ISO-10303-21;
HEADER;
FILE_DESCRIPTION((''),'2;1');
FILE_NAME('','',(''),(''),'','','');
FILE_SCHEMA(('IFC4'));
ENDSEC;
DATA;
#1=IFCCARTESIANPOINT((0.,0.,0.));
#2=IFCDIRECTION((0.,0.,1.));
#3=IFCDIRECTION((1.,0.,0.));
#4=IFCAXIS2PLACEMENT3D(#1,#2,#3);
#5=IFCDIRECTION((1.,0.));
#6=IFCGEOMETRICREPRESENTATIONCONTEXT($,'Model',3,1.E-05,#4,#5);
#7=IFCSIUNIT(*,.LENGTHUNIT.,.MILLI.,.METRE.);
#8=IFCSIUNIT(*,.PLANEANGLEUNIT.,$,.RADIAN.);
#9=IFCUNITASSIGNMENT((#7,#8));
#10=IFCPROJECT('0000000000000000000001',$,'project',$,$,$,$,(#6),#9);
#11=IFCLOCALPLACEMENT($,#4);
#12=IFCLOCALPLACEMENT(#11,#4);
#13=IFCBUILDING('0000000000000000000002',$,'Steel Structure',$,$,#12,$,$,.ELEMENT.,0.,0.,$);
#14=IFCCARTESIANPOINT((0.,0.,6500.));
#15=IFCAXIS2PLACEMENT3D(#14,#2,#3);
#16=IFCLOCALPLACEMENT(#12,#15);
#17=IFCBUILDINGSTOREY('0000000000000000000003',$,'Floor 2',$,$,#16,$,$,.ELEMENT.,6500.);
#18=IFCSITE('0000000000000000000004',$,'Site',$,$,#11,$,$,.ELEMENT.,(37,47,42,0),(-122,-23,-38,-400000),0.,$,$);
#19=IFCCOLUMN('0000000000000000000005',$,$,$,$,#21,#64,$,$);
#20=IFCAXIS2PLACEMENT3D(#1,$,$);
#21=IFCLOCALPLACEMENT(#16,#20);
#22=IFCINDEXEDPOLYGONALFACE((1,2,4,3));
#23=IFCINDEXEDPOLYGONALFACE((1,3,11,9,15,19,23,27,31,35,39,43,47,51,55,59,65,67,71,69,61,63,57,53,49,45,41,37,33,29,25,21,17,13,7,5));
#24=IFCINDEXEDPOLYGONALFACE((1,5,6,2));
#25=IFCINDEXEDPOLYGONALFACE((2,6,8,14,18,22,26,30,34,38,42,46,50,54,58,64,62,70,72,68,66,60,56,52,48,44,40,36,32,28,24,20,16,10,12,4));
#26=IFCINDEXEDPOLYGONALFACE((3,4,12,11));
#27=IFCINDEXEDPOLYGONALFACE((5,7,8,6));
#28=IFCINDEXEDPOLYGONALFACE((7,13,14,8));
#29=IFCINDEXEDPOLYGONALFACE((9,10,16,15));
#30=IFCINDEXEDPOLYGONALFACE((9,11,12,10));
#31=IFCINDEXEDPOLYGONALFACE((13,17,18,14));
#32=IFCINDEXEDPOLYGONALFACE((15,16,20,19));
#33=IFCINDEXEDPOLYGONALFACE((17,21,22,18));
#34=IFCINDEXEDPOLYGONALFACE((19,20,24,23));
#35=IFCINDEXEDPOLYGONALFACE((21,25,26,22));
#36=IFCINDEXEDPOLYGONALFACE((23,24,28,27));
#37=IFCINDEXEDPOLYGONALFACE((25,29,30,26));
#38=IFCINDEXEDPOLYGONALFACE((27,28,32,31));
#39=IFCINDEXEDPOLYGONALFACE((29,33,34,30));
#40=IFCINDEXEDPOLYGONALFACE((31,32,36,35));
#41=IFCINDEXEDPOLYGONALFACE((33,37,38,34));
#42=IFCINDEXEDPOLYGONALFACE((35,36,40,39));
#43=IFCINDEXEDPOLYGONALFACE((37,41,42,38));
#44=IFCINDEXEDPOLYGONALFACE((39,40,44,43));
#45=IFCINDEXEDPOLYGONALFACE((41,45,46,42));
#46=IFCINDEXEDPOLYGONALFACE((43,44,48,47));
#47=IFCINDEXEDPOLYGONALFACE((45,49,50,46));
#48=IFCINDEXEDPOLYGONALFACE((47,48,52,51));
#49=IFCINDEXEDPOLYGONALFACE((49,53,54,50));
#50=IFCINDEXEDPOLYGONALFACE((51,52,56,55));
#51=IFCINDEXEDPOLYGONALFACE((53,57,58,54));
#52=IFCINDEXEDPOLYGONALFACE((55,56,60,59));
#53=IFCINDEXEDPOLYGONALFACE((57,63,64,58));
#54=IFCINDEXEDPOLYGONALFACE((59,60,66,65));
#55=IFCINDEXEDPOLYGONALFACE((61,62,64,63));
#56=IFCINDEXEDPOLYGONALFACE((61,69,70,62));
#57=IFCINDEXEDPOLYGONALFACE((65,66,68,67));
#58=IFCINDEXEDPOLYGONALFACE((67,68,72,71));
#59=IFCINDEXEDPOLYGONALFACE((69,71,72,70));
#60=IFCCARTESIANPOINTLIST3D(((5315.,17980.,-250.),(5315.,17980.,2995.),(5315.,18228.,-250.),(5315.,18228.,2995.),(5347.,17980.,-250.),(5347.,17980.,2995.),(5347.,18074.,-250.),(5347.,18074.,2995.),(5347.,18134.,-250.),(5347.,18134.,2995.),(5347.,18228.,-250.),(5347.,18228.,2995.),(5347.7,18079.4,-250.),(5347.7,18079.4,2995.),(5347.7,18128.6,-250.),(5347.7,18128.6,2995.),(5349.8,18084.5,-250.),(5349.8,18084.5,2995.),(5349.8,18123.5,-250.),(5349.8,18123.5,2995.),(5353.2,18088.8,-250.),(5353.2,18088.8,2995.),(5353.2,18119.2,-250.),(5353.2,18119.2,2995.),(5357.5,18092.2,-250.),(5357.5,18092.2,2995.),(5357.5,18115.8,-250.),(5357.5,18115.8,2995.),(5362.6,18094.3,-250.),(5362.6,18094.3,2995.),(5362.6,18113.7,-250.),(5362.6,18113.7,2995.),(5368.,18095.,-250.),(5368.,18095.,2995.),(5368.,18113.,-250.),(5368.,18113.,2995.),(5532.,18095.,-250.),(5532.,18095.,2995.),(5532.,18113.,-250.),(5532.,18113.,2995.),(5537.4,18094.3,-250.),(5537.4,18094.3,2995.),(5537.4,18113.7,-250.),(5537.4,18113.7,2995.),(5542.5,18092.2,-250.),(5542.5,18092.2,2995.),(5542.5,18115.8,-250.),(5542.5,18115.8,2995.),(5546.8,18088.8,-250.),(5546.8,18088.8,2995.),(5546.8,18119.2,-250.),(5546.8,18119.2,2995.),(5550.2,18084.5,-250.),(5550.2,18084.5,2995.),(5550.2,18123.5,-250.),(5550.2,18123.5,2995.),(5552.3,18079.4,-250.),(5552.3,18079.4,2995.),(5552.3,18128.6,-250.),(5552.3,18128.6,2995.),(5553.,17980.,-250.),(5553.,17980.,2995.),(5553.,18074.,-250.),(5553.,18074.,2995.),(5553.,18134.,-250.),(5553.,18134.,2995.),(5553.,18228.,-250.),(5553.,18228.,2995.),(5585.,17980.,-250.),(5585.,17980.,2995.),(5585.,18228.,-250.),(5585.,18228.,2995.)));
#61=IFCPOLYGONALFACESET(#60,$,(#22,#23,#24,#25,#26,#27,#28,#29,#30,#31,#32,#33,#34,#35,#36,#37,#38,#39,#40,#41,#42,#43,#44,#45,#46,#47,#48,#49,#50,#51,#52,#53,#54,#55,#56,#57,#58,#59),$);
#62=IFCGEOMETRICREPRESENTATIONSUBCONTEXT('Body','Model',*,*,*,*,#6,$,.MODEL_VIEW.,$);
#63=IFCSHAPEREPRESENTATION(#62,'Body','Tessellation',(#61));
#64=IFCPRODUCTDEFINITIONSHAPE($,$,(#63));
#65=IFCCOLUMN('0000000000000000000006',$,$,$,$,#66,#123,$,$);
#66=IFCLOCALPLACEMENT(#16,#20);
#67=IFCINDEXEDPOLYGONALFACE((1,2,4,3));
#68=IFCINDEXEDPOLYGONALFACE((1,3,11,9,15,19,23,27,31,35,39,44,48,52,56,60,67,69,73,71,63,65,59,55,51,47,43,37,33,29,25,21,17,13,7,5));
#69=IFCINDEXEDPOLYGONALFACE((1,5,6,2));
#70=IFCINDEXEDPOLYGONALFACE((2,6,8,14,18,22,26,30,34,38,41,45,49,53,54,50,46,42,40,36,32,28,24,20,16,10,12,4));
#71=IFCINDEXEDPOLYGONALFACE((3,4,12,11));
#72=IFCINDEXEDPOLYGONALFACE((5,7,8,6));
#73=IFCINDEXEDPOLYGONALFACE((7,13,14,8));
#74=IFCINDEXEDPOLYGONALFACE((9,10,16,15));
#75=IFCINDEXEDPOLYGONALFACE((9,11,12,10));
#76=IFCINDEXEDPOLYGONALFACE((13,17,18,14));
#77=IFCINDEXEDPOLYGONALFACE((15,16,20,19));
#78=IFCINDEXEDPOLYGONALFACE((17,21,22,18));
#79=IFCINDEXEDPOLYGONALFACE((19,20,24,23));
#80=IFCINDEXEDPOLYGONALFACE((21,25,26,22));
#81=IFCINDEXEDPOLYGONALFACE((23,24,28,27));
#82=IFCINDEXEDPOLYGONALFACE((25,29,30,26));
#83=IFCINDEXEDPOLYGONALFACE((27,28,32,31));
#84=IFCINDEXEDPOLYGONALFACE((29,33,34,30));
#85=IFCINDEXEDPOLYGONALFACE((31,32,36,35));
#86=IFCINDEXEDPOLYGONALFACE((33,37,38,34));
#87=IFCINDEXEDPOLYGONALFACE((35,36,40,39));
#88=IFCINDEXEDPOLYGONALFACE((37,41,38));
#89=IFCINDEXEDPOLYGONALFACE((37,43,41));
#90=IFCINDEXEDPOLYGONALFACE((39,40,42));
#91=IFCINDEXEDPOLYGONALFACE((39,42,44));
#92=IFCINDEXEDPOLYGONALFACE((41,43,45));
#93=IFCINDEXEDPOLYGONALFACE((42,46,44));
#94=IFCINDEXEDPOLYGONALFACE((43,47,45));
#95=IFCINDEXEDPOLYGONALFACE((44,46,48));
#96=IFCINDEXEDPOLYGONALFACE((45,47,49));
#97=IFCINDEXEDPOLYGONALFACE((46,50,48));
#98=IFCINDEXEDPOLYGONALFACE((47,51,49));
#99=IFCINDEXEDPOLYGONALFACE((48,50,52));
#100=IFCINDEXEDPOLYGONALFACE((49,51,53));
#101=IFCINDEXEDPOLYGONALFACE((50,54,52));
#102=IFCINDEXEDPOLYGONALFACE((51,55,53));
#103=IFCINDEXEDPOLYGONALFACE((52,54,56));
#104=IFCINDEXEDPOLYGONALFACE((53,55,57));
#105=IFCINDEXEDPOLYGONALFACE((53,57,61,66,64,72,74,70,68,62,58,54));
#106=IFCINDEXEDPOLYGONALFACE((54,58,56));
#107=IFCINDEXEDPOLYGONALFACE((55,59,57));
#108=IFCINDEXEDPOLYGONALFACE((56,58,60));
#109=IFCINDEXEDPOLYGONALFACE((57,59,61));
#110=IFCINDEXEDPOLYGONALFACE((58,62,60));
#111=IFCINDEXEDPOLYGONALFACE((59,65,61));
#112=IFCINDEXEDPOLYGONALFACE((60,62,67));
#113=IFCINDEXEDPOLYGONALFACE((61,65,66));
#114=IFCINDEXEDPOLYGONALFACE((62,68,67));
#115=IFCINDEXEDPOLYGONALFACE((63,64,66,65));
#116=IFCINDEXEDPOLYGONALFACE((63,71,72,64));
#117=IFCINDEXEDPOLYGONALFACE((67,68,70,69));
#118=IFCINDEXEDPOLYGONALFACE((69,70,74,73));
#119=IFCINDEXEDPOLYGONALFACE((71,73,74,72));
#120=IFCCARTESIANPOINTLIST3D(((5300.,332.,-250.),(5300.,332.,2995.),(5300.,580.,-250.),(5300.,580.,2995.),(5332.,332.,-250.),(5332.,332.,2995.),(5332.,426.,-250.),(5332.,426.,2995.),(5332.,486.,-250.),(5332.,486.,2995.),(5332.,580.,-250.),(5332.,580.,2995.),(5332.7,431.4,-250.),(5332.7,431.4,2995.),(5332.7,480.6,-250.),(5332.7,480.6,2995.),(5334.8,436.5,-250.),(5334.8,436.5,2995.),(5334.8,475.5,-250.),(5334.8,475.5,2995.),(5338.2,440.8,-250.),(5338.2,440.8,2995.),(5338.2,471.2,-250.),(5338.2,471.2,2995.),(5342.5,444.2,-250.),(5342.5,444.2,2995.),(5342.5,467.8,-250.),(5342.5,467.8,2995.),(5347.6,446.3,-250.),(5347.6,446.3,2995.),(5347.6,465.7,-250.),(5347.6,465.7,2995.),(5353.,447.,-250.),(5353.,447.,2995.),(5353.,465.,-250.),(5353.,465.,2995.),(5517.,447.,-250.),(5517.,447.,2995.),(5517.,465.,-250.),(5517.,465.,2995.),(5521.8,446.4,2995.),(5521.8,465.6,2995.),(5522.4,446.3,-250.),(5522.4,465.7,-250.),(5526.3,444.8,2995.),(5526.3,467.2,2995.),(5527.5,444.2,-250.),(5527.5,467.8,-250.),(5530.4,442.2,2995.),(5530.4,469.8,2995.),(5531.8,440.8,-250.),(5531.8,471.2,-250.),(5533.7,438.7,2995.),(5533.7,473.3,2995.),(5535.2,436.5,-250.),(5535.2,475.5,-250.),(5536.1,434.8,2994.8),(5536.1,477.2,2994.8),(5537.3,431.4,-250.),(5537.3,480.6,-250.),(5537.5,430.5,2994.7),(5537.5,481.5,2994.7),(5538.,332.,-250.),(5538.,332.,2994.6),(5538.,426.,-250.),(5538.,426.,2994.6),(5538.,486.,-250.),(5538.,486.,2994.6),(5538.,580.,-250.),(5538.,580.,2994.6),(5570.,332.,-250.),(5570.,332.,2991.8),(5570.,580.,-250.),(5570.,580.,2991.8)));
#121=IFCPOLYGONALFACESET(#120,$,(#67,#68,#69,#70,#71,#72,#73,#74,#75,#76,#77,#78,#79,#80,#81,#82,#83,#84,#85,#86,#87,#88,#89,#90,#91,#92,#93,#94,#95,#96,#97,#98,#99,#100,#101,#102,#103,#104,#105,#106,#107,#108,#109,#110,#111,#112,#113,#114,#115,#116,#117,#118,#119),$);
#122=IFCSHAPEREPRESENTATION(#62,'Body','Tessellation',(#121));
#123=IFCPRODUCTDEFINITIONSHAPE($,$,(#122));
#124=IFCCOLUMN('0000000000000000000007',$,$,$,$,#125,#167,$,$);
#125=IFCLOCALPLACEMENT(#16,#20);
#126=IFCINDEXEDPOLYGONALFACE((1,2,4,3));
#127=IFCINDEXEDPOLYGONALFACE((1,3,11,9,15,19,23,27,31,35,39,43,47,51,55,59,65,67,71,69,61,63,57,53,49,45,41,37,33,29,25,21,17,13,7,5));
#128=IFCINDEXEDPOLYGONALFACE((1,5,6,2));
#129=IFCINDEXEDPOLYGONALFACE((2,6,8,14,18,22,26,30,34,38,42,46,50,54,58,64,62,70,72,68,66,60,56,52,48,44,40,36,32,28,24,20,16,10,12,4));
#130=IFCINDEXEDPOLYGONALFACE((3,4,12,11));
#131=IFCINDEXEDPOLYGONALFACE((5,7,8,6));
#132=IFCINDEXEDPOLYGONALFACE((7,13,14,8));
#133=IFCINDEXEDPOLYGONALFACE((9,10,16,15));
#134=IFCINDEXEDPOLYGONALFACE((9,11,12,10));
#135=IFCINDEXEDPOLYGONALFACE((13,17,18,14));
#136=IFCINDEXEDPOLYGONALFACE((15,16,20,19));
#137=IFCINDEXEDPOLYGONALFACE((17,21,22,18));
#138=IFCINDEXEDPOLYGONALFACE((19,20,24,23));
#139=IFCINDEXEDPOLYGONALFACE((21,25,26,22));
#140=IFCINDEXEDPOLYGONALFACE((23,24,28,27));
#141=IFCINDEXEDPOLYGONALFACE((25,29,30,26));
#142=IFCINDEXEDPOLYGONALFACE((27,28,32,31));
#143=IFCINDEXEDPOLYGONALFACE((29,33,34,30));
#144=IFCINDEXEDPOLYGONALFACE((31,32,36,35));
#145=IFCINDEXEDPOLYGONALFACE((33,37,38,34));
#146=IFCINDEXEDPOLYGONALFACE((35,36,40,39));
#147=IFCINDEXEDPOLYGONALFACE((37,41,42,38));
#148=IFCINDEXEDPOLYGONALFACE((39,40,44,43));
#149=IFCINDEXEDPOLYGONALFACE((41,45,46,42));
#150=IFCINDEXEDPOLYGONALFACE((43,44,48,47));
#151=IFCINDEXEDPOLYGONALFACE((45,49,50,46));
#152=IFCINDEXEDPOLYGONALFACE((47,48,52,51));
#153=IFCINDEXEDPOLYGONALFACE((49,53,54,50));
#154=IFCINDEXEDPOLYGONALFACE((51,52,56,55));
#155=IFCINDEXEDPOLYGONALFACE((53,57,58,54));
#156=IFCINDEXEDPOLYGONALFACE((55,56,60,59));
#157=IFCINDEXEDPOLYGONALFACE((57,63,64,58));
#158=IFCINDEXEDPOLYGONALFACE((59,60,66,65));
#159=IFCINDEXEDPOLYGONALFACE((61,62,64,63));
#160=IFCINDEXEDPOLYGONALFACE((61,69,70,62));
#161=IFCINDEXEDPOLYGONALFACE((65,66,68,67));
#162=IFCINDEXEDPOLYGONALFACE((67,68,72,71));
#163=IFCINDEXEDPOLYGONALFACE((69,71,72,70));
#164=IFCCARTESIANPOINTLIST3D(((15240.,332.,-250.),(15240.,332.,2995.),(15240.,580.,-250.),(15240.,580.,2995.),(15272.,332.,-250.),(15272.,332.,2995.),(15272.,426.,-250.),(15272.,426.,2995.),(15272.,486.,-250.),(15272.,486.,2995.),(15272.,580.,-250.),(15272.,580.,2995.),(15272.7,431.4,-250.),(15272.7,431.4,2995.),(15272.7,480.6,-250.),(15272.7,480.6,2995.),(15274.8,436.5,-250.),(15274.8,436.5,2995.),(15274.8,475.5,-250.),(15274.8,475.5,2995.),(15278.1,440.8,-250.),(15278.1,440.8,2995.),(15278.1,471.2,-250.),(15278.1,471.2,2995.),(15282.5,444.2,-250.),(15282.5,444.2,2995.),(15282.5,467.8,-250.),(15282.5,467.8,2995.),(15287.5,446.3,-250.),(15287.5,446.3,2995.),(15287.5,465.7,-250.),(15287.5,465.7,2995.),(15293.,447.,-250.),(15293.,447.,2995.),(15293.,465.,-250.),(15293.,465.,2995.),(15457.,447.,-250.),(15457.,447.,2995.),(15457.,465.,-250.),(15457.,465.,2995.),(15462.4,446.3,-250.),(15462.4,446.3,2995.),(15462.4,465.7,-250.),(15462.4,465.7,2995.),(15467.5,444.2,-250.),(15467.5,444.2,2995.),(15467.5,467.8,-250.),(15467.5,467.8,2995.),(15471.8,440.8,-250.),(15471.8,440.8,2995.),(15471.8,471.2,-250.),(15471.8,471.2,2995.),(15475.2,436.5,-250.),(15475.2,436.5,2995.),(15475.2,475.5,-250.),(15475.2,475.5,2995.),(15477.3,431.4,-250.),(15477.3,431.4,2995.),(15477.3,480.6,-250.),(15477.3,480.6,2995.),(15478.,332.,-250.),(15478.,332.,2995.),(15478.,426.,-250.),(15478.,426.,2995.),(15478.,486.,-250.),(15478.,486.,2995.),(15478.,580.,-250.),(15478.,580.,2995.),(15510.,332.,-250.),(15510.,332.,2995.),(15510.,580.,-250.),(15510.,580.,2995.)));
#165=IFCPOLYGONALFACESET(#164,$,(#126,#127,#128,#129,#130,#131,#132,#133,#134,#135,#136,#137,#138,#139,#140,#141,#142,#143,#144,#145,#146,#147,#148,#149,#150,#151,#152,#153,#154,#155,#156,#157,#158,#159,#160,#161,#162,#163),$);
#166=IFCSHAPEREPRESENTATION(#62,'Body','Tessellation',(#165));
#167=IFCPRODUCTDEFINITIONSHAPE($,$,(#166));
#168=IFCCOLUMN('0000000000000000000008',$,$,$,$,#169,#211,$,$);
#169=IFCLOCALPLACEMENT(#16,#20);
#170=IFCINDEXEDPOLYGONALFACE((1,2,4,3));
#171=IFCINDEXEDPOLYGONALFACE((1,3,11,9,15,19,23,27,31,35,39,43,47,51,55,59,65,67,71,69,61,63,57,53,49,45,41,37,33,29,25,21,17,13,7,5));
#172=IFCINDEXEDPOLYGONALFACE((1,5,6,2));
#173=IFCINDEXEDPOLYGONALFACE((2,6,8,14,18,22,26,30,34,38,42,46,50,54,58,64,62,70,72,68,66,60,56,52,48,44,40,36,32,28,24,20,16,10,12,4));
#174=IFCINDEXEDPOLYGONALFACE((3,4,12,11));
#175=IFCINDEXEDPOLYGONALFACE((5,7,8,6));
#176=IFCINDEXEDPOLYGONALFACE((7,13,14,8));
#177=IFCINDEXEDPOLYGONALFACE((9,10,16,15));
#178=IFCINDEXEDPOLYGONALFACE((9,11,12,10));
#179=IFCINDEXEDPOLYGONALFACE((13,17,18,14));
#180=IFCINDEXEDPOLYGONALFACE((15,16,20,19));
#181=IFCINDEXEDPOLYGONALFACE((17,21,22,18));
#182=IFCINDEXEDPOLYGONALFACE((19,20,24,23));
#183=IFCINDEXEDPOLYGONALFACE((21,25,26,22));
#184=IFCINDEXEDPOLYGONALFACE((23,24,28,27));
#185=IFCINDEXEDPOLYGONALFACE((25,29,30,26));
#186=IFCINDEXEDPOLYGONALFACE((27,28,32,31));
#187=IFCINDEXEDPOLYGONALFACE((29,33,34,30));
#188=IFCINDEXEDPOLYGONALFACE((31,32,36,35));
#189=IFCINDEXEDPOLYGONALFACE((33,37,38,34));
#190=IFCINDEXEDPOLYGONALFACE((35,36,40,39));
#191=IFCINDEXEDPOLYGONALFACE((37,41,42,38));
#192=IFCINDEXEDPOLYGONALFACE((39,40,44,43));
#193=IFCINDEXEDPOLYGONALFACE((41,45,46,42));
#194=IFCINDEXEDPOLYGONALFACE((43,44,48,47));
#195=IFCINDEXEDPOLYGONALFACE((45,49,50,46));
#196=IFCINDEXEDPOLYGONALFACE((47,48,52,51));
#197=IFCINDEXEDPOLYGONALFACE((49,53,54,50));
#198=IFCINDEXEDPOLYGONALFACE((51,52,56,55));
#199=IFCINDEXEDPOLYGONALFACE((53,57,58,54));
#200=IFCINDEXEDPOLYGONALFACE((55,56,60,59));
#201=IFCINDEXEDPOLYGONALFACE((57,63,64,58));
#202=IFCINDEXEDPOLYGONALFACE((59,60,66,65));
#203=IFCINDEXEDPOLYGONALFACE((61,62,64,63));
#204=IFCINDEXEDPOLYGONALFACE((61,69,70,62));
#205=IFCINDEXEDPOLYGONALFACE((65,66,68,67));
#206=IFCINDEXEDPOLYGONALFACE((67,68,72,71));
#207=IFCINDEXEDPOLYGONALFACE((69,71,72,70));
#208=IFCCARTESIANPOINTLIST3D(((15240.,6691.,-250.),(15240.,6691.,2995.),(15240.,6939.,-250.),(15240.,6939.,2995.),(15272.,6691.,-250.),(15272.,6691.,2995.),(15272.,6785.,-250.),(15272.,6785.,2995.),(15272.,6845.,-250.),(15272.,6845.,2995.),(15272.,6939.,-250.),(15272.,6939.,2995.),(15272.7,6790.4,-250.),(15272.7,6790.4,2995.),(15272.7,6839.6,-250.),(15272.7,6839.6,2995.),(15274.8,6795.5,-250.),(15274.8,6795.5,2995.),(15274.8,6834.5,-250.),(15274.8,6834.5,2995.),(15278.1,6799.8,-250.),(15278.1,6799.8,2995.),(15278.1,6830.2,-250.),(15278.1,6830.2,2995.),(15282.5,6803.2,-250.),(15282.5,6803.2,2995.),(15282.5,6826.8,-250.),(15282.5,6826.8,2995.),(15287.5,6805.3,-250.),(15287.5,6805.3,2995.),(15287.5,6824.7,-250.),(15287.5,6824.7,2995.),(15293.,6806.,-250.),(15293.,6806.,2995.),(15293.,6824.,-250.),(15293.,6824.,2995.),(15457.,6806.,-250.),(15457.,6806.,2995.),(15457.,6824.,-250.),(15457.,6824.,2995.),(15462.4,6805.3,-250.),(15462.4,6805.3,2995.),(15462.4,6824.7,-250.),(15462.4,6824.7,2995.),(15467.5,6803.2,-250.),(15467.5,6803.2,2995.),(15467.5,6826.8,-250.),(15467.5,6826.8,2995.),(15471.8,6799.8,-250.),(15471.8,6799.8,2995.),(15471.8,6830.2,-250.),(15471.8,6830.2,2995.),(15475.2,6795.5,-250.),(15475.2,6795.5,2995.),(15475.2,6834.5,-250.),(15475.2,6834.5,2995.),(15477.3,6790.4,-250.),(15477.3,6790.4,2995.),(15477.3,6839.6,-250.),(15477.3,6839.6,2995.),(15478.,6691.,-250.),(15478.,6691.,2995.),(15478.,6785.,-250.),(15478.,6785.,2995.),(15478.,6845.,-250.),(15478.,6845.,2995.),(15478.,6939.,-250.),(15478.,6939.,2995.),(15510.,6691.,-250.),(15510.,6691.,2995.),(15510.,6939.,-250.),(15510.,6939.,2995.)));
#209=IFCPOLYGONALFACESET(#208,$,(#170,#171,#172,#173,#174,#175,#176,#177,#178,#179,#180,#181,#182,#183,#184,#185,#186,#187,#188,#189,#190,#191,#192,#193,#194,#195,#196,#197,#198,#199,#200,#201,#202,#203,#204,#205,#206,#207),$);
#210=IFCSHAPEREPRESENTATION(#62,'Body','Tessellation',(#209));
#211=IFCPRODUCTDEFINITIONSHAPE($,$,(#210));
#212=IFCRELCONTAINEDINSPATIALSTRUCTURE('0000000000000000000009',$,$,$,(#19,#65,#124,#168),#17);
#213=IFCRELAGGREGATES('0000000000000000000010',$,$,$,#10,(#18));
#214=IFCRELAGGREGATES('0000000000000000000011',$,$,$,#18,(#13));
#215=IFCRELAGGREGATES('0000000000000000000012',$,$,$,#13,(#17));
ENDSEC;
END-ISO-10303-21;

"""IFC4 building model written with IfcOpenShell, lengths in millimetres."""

from ifc_helpers import new_model, si_unit, direction, frame, origin_with_axes, origin_2d_with_axis, place, context, subcontext, project, spatial, polyline, i_section, extrude, clip, bounded_halfspace, element, save


model = new_model("IFC4")

# Units and contexts
model_context = context("Model", 3, precision=1e-05, world=origin_with_axes(), true_north=direction((1.0, 0.0)))
body_context = subcontext(model_context, "Body", "Model", "MODEL_VIEW")
ifc_project = project(units=[si_unit("LENGTHUNIT", "METRE", prefix="MILLI"), si_unit("PLANEANGLEUNIT", "RADIAN")], contexts=[model_context])

# Site, building, storey
site_placement = place(None, origin_with_axes())
site = spatial("IfcSite", under=ifc_project, at=site_placement, Name="Site", CompositionType="ELEMENT", RefLatitude=(37, 47, 42, 0), RefLongitude=(-122, -23, -38, -400000), RefElevation=0.0)
building_placement = place(site_placement, origin_with_axes())
building = spatial("IfcBuilding", under=site, at=building_placement, Name="Steel Structure", CompositionType="ELEMENT", ElevationOfRefHeight=0.0, ElevationOfTerrain=0.0)
storey_placement = place(building_placement, frame((0.0, 0.0, 6500.0), z_axis=(0.0, 0.0, 1.0), x_axis=(1.0, 0.0, 0.0)))
storey = spatial("IfcBuildingStorey", under=building, at=storey_placement, Name="Floor 2", CompositionType="ELEMENT", Elevation=6500.0)

# Columns
column_1_placement = place(storey_placement, frame((5450.0, 18104.0, -250.0), z_axis=(0.0, 0.0, 1.0), x_axis=(0.0, -1.0, 0.0)))
element("IfcColumn", 1, at=column_1_placement, inside=storey, context=body_context, shape_type="SweptSolid", body=[
    extrude(i_section(OverallWidth=248.0, OverallDepth=270.0, WebThickness=18.0, FlangeThickness=32.0, FilletRadius=21.0, at=origin_2d_with_axis()), origin_with_axes(), (0.0, 0.0, 1.0), 3245.0),
])
column_2_placement = place(storey_placement, frame((5435.0, 456.0, -250.0), z_axis=(0.0, 0.0, 1.0), x_axis=(0.0, 1.0, 0.0)))
element("IfcColumn", 2, at=column_2_placement, inside=storey, context=body_context, shape_type="Clipping", body=[
    clip(extrude(i_section(OverallWidth=248.0, OverallDepth=270.0, WebThickness=18.0, FlangeThickness=32.0, FilletRadius=21.0, at=origin_2d_with_axis()), origin_with_axes(), (0.0, 0.0, 1.0), 3245.0), bounded_halfspace(frame((-456.0, 4568.6, 3653.3), z_axis=(0.0, -0.087156, 0.996195), x_axis=(1.0, 0.0, 0.0)), False, origin_with_axes(), polyline([(-17.3, -98.7), (-30.0, -103.0), (-124.0, -103.0), (-124.0, -135.0), (124.0, -135.0), (124.0, -103.0), (30.0, -103.0), (17.3, -98.7), (-17.3, -98.7)]))),
])
column_3_placement = place(storey_placement, frame((15375.0, 456.0, -250.0), z_axis=(0.0, 0.0, 1.0), x_axis=(0.0, 1.0, 0.0)))
element("IfcColumn", 3, at=column_3_placement, inside=storey, context=body_context, shape_type="SweptSolid", body=[
    extrude(i_section(OverallWidth=248.0, OverallDepth=270.0, WebThickness=18.0, FlangeThickness=32.0, FilletRadius=21.0, at=origin_2d_with_axis()), origin_with_axes(), (0.0, 0.0, 1.0), 3245.0),
])
column_4_placement = place(storey_placement, frame((15375.0, 6815.0, -250.0), z_axis=(0.0, 0.0, 1.0), x_axis=(0.0, -1.0, 0.0)))
element("IfcColumn", 4, at=column_4_placement, inside=storey, context=body_context, shape_type="SweptSolid", body=[
    extrude(i_section(OverallWidth=248.0, OverallDepth=270.0, WebThickness=18.0, FlangeThickness=32.0, FilletRadius=21.0, at=origin_2d_with_axis()), origin_with_axes(), (0.0, 0.0, 1.0), 3245.0),
])

save(model, "model.ifc")
